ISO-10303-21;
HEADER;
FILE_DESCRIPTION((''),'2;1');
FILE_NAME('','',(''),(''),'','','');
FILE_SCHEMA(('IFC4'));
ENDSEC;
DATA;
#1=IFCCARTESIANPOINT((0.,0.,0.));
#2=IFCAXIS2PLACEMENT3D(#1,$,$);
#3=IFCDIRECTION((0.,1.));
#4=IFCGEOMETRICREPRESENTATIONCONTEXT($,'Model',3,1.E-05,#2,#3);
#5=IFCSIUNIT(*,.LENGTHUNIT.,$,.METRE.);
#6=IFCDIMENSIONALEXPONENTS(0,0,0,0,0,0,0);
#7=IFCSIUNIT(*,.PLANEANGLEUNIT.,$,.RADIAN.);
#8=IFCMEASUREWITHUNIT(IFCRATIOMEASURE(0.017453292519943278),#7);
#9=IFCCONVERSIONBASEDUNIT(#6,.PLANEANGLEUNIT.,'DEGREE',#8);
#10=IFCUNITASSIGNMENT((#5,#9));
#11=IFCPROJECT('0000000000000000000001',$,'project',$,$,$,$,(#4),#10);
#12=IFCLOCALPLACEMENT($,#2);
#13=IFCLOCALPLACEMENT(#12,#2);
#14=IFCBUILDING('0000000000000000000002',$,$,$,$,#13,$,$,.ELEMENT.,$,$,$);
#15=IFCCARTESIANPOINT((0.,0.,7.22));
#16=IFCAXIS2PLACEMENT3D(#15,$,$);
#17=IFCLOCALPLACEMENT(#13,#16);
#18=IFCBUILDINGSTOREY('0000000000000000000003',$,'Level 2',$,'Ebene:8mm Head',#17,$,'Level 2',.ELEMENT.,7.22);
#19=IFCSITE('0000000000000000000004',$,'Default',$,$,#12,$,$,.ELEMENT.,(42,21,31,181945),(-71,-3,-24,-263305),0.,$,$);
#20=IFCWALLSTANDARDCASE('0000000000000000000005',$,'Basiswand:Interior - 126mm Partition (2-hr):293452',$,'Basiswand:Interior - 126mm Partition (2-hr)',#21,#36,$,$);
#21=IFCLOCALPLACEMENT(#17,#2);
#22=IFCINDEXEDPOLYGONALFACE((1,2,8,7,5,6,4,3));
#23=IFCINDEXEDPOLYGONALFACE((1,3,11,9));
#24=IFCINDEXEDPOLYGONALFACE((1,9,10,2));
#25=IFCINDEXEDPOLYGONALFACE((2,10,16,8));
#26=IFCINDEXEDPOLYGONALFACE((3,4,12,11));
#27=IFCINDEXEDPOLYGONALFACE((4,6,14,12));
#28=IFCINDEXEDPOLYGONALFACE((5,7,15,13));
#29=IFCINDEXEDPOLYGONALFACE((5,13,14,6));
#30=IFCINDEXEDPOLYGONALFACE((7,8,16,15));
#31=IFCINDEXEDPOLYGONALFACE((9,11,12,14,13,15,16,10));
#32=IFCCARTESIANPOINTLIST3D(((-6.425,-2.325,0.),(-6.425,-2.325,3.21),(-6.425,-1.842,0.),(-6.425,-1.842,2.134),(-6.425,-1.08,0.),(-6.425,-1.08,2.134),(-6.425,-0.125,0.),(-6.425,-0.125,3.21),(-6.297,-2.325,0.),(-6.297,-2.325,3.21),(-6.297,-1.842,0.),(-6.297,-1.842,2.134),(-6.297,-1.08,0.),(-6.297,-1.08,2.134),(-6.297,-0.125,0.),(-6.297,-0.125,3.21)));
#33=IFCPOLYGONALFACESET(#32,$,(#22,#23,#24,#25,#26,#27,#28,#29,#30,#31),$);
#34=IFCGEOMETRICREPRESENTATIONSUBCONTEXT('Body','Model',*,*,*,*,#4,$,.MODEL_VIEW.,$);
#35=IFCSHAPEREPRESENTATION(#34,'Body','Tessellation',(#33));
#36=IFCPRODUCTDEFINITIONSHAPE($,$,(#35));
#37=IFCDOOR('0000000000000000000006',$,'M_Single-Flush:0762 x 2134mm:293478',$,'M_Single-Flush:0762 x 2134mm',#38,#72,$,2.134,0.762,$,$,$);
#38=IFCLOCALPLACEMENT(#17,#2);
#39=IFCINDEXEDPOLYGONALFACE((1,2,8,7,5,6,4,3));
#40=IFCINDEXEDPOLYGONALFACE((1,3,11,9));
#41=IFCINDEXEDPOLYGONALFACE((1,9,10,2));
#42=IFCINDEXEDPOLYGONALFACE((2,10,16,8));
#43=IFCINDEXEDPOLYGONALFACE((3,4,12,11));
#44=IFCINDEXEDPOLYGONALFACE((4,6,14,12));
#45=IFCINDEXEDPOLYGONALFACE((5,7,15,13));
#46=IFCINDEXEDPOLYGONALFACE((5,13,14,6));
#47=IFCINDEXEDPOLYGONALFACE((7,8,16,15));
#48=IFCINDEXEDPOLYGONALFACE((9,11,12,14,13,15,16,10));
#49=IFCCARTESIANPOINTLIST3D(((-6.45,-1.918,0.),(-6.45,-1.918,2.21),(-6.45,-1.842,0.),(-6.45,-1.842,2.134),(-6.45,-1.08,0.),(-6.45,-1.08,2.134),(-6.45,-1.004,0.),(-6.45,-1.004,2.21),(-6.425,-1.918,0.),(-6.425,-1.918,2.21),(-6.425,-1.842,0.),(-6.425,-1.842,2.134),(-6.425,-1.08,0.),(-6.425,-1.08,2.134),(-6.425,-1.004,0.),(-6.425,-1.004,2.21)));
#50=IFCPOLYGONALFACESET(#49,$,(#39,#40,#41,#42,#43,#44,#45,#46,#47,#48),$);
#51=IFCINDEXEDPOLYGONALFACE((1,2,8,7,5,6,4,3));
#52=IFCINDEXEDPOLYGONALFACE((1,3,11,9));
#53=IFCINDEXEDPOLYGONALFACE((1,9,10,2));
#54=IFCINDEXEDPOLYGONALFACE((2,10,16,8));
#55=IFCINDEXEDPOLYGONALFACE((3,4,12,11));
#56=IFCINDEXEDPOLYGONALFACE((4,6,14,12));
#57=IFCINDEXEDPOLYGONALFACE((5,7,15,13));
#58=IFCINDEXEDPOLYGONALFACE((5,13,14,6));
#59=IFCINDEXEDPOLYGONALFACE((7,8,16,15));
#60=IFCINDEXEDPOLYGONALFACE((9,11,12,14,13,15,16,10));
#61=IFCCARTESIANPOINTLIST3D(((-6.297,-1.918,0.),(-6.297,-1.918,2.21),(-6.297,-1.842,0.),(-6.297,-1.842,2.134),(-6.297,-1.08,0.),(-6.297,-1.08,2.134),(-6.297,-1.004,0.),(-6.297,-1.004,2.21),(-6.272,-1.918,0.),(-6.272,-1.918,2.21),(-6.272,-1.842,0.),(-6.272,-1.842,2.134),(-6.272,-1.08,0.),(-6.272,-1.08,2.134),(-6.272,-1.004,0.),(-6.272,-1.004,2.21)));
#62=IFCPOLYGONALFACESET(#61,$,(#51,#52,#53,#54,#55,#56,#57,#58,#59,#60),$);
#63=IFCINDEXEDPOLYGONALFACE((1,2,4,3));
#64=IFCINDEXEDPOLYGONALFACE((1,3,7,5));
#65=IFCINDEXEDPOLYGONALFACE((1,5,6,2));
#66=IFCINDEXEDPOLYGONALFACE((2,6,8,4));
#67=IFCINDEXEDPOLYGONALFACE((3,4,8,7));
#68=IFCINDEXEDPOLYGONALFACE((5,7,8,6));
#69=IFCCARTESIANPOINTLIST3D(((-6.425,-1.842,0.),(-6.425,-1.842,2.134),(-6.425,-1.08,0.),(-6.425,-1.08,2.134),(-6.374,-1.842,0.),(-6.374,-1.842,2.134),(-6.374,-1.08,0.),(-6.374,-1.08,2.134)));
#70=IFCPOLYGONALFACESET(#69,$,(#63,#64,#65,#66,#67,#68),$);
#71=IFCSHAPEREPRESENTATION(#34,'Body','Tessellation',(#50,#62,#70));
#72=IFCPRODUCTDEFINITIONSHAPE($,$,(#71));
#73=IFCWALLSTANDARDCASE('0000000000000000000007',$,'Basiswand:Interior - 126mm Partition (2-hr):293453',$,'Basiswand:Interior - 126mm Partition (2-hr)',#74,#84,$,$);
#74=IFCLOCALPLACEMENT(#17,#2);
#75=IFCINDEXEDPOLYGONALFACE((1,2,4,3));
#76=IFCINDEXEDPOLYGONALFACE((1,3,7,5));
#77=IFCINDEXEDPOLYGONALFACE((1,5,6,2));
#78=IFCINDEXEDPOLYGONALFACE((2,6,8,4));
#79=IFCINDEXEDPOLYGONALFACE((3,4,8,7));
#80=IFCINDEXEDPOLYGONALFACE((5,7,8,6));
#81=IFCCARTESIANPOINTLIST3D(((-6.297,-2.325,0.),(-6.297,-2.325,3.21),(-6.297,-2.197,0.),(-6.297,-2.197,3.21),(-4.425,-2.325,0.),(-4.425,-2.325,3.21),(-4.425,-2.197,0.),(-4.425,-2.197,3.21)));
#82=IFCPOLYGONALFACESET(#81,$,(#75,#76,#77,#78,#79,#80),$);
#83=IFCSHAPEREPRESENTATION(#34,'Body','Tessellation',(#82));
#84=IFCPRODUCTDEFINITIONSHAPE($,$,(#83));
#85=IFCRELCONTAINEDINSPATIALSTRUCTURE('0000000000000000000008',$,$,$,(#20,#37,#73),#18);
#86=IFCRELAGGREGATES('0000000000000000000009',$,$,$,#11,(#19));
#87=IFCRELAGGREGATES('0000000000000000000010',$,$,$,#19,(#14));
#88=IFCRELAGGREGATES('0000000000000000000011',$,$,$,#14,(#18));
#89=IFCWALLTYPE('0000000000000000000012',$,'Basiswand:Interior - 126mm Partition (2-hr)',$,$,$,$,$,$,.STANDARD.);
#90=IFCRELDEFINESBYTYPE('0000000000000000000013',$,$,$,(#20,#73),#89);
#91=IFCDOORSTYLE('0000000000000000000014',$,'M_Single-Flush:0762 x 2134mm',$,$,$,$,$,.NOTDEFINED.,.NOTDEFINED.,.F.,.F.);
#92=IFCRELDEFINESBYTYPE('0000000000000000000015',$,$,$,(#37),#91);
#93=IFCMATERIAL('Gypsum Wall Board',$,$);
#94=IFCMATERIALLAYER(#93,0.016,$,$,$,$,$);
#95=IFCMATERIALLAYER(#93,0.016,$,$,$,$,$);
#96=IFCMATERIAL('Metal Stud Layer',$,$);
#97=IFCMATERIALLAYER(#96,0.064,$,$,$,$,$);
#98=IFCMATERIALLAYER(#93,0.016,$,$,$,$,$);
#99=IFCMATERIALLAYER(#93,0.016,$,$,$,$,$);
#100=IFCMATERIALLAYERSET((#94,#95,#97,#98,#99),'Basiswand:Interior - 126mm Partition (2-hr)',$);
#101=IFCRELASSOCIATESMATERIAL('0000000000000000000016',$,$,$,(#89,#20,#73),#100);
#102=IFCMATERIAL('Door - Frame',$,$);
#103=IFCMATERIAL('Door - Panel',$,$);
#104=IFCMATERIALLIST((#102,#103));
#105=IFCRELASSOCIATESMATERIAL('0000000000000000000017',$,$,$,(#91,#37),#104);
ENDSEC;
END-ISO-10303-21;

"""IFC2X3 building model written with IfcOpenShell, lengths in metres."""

from ifc_helpers import new_model, entity, si_unit, converted_unit, direction, frame, frame_2d, origin, place, context, subcontext, project, spatial, polyline, rectangle, outline, extrude, clip, bounded_halfspace, source, transform, mapped, material, material_list, layer, layer_set, layer_usage, type_object, type_shapes, element, fill, save


model = new_model("IFC2X3")

# Units and contexts
model_context = context("Model", 3, precision=1e-05, world=origin(), true_north=direction((0.0, 1.0)))
body_context = subcontext(model_context, "Body", "Model", "MODEL_VIEW")
ifc_project = project(units=[si_unit("LENGTHUNIT", "METRE"), converted_unit("PLANEANGLEUNIT", "DEGREE", entity("IfcRatioMeasure", 0.017453292519943278), si_unit("PLANEANGLEUNIT", "RADIAN"), dimensions=[0, 0, 0, 0, 0, 0, 0])], contexts=[model_context])

# Site, building, storey
site_placement = place(None, origin())
site = spatial("IfcSite", under=ifc_project, at=site_placement, Name="Default", CompositionType="ELEMENT", RefLatitude=(42, 21, 31, 181945), RefLongitude=(-71, -3, -24, -263305), RefElevation=0.0)
building_placement = place(site_placement, origin())
building = spatial("IfcBuilding", under=site, at=building_placement, CompositionType="ELEMENT")
storey_placement = place(building_placement, frame((0.0, 0.0, 7.22)))
storey = spatial("IfcBuildingStorey", under=building, at=storey_placement, Name="Level 2", ObjectType="Ebene:8mm Head", LongName="Level 2", CompositionType="ELEMENT", Elevation=7.22)

# Shared definitions
ifc_material_1 = material(Name="Door - Frame")
ifc_material_2 = material(Name="Door - Panel")
ifc_material_list_1 = material_list([ifc_material_1, ifc_material_2])

# Shared definitions
ifc_material_3 = material(Name="Gypsum Wall Board")
ifc_layer_1 = layer(ifc_material_3, 0.016)
ifc_layer_2 = layer(ifc_material_3, 0.016)
ifc_material_4 = material(Name="Metal Stud Layer")
ifc_layer_3 = layer(ifc_material_4, 0.064)
ifc_layer_4 = layer(ifc_material_3, 0.016)
ifc_layer_5 = layer(ifc_material_3, 0.016)
ifc_layer_set_1 = layer_set([ifc_layer_1, ifc_layer_2, ifc_layer_3, ifc_layer_4, ifc_layer_5], Name="Basiswand:Interior - 126mm Partition (2-hr)")
wall_type_1 = type_object("IfcWallType", Name="Basiswand:Interior - 126mm Partition (2-hr)", PredefinedType="STANDARD", material=ifc_layer_set_1)

# Wall, opening, door
ifc_layer_usage_1 = layer_usage(ifc_layer_set_1, "AXIS2", "POSITIVE", -0.064)
wall_1_placement = place(storey_placement, frame((-6.361, -0.125, 0.0), z_axis=(0.0, 0.0, 1.0), x_axis=(0.0, -1.0, 0.0)))
wall_1 = element("IfcWallStandardCase", 1, at=wall_1_placement, inside=storey, type_object=wall_type_1, material=ifc_layer_usage_1, Name="Basiswand:Interior - 126mm Partition (2-hr):293452", ObjectType="Basiswand:Interior - 126mm Partition (2-hr)", context=body_context, shape_type="Clipping", body=[
    clip(extrude(rectangle(XDim=2.2, YDim=0.128, at=frame_2d((1.1, 0.0), x_axis=(1.0, 0.0))), origin(), (0.0, 0.0, 1.0), 3.21), bounded_halfspace(frame((0.0, -0.064, 3.21), z_axis=(0.0, 0.0, -1.0), x_axis=(-1.0, 0.0, 0.0)), True, frame((0.0, -0.064, 3.21)), polyline([(0.0, 0.0), (2.2, 0.0), (2.2, 0.128), (2.072, 0.128), (0.0, 0.128), (0.0, 0.0)]))),
])
opening_1_placement = place(wall_1_placement, frame((1.717, 0.064, 0.0)))
opening_1 = element("IfcOpeningElement", 2, at=opening_1_placement, cuts=wall_1, ObjectType="Opening", context=body_context, shape_type="SweptSolid", body=[
    extrude(rectangle(XDim=0.762, YDim=2.134, at=frame_2d((1.067, 0.381), x_axis=(0.0, -1.0))), frame((0.0, 0.0, 0.0), z_axis=(0.0, -1.0, 0.0), x_axis=(0.0, 0.0, 1.0)), (0.0, 0.0, 1.0), 0.128),
])
door_style_1 = type_object("IfcDoorStyle", Name="M_Single-Flush:0762 x 2134mm", ConstructionType="NOTDEFINED", OperationType="NOTDEFINED", ParameterTakesPrecedence=False, Sizeable=False, material=ifc_material_list_1)
shared_shape_1 = source(origin(), body_context, "Body", "SweptSolid", [
    extrude(outline(polyline([(-0.457, -1.124), (0.457, -1.124), (0.457, 1.086), (0.381, 1.086), (0.381, -1.048), (-0.381, -1.048), (-0.381, 1.086), (-0.457, 1.086), (-0.457, -1.124)])), frame((0.381, 0.153, 1.086), z_axis=(0.0, -1.0, 0.0), x_axis=(-1.0, 0.0, 0.0)), (0.0, 0.0, 1.0), 0.025),
    extrude(outline(polyline([(-1.124, -0.457), (1.086, -0.457), (1.086, -0.381), (-1.048, -0.381), (-1.048, 0.381), (1.086, 0.381), (1.086, 0.457), (-1.124, 0.457), (-1.124, -0.457)])), frame((0.381, 0.0, 1.086), z_axis=(0.0, -1.0, 0.0), x_axis=(0.0, 0.0, -1.0)), (0.0, 0.0, 1.0), 0.025),
    extrude(rectangle(XDim=0.762, YDim=0.051, at=frame_2d((0.0, 0.0), x_axis=(1.0, 0.0))), frame((0.381, 0.1025, 0.0)), (0.0, 0.0, 1.0), 2.134),
])
type_shapes(door_style_1, [shared_shape_1])
door_1_placement = place(opening_1_placement, frame((0.0, 0.0, 0.0), z_axis=(0.0, 0.0, 1.0), x_axis=(-1.0, 0.0, 0.0)))
door_1 = element("IfcDoor", 3, at=door_1_placement, inside=storey, type_object=door_style_1, material=ifc_material_list_1, Name="M_Single-Flush:0762 x 2134mm:293478", ObjectType="M_Single-Flush:0762 x 2134mm", OverallHeight=2.134, OverallWidth=0.762, context=body_context, shape_type="MappedRepresentation", body=[
    mapped(shared_shape_1, transform((0.0, 0.0, 0.0), scale=1.0)),
])
fill(opening_1, door_1)

# Wall
wall_2_placement = place(storey_placement, frame((-6.297, -2.261, 0.0)))
element("IfcWallStandardCase", 4, at=wall_2_placement, inside=storey, type_object=wall_type_1, material=ifc_layer_usage_1, Name="Basiswand:Interior - 126mm Partition (2-hr):293453", ObjectType="Basiswand:Interior - 126mm Partition (2-hr)", context=body_context, shape_type="Clipping", body=[
    clip(extrude(rectangle(XDim=1.872, YDim=0.128, at=frame_2d((0.936, 0.0), x_axis=(-1.0, 0.0))), origin(), (0.0, 0.0, 1.0), 3.21), bounded_halfspace(frame((0.0, -0.064, 3.21), z_axis=(0.0, 0.0, -1.0), x_axis=(0.0, 1.0, 0.0)), True, frame((0.0, -0.064, 3.21)), polyline([(0.0, 0.0), (1.872, 0.0), (1.872, 0.128), (1.322, 0.128), (1.194, 0.128), (0.0, 0.128), (0.0, 0.0)]))),
])

save(model, "model.ifc")
